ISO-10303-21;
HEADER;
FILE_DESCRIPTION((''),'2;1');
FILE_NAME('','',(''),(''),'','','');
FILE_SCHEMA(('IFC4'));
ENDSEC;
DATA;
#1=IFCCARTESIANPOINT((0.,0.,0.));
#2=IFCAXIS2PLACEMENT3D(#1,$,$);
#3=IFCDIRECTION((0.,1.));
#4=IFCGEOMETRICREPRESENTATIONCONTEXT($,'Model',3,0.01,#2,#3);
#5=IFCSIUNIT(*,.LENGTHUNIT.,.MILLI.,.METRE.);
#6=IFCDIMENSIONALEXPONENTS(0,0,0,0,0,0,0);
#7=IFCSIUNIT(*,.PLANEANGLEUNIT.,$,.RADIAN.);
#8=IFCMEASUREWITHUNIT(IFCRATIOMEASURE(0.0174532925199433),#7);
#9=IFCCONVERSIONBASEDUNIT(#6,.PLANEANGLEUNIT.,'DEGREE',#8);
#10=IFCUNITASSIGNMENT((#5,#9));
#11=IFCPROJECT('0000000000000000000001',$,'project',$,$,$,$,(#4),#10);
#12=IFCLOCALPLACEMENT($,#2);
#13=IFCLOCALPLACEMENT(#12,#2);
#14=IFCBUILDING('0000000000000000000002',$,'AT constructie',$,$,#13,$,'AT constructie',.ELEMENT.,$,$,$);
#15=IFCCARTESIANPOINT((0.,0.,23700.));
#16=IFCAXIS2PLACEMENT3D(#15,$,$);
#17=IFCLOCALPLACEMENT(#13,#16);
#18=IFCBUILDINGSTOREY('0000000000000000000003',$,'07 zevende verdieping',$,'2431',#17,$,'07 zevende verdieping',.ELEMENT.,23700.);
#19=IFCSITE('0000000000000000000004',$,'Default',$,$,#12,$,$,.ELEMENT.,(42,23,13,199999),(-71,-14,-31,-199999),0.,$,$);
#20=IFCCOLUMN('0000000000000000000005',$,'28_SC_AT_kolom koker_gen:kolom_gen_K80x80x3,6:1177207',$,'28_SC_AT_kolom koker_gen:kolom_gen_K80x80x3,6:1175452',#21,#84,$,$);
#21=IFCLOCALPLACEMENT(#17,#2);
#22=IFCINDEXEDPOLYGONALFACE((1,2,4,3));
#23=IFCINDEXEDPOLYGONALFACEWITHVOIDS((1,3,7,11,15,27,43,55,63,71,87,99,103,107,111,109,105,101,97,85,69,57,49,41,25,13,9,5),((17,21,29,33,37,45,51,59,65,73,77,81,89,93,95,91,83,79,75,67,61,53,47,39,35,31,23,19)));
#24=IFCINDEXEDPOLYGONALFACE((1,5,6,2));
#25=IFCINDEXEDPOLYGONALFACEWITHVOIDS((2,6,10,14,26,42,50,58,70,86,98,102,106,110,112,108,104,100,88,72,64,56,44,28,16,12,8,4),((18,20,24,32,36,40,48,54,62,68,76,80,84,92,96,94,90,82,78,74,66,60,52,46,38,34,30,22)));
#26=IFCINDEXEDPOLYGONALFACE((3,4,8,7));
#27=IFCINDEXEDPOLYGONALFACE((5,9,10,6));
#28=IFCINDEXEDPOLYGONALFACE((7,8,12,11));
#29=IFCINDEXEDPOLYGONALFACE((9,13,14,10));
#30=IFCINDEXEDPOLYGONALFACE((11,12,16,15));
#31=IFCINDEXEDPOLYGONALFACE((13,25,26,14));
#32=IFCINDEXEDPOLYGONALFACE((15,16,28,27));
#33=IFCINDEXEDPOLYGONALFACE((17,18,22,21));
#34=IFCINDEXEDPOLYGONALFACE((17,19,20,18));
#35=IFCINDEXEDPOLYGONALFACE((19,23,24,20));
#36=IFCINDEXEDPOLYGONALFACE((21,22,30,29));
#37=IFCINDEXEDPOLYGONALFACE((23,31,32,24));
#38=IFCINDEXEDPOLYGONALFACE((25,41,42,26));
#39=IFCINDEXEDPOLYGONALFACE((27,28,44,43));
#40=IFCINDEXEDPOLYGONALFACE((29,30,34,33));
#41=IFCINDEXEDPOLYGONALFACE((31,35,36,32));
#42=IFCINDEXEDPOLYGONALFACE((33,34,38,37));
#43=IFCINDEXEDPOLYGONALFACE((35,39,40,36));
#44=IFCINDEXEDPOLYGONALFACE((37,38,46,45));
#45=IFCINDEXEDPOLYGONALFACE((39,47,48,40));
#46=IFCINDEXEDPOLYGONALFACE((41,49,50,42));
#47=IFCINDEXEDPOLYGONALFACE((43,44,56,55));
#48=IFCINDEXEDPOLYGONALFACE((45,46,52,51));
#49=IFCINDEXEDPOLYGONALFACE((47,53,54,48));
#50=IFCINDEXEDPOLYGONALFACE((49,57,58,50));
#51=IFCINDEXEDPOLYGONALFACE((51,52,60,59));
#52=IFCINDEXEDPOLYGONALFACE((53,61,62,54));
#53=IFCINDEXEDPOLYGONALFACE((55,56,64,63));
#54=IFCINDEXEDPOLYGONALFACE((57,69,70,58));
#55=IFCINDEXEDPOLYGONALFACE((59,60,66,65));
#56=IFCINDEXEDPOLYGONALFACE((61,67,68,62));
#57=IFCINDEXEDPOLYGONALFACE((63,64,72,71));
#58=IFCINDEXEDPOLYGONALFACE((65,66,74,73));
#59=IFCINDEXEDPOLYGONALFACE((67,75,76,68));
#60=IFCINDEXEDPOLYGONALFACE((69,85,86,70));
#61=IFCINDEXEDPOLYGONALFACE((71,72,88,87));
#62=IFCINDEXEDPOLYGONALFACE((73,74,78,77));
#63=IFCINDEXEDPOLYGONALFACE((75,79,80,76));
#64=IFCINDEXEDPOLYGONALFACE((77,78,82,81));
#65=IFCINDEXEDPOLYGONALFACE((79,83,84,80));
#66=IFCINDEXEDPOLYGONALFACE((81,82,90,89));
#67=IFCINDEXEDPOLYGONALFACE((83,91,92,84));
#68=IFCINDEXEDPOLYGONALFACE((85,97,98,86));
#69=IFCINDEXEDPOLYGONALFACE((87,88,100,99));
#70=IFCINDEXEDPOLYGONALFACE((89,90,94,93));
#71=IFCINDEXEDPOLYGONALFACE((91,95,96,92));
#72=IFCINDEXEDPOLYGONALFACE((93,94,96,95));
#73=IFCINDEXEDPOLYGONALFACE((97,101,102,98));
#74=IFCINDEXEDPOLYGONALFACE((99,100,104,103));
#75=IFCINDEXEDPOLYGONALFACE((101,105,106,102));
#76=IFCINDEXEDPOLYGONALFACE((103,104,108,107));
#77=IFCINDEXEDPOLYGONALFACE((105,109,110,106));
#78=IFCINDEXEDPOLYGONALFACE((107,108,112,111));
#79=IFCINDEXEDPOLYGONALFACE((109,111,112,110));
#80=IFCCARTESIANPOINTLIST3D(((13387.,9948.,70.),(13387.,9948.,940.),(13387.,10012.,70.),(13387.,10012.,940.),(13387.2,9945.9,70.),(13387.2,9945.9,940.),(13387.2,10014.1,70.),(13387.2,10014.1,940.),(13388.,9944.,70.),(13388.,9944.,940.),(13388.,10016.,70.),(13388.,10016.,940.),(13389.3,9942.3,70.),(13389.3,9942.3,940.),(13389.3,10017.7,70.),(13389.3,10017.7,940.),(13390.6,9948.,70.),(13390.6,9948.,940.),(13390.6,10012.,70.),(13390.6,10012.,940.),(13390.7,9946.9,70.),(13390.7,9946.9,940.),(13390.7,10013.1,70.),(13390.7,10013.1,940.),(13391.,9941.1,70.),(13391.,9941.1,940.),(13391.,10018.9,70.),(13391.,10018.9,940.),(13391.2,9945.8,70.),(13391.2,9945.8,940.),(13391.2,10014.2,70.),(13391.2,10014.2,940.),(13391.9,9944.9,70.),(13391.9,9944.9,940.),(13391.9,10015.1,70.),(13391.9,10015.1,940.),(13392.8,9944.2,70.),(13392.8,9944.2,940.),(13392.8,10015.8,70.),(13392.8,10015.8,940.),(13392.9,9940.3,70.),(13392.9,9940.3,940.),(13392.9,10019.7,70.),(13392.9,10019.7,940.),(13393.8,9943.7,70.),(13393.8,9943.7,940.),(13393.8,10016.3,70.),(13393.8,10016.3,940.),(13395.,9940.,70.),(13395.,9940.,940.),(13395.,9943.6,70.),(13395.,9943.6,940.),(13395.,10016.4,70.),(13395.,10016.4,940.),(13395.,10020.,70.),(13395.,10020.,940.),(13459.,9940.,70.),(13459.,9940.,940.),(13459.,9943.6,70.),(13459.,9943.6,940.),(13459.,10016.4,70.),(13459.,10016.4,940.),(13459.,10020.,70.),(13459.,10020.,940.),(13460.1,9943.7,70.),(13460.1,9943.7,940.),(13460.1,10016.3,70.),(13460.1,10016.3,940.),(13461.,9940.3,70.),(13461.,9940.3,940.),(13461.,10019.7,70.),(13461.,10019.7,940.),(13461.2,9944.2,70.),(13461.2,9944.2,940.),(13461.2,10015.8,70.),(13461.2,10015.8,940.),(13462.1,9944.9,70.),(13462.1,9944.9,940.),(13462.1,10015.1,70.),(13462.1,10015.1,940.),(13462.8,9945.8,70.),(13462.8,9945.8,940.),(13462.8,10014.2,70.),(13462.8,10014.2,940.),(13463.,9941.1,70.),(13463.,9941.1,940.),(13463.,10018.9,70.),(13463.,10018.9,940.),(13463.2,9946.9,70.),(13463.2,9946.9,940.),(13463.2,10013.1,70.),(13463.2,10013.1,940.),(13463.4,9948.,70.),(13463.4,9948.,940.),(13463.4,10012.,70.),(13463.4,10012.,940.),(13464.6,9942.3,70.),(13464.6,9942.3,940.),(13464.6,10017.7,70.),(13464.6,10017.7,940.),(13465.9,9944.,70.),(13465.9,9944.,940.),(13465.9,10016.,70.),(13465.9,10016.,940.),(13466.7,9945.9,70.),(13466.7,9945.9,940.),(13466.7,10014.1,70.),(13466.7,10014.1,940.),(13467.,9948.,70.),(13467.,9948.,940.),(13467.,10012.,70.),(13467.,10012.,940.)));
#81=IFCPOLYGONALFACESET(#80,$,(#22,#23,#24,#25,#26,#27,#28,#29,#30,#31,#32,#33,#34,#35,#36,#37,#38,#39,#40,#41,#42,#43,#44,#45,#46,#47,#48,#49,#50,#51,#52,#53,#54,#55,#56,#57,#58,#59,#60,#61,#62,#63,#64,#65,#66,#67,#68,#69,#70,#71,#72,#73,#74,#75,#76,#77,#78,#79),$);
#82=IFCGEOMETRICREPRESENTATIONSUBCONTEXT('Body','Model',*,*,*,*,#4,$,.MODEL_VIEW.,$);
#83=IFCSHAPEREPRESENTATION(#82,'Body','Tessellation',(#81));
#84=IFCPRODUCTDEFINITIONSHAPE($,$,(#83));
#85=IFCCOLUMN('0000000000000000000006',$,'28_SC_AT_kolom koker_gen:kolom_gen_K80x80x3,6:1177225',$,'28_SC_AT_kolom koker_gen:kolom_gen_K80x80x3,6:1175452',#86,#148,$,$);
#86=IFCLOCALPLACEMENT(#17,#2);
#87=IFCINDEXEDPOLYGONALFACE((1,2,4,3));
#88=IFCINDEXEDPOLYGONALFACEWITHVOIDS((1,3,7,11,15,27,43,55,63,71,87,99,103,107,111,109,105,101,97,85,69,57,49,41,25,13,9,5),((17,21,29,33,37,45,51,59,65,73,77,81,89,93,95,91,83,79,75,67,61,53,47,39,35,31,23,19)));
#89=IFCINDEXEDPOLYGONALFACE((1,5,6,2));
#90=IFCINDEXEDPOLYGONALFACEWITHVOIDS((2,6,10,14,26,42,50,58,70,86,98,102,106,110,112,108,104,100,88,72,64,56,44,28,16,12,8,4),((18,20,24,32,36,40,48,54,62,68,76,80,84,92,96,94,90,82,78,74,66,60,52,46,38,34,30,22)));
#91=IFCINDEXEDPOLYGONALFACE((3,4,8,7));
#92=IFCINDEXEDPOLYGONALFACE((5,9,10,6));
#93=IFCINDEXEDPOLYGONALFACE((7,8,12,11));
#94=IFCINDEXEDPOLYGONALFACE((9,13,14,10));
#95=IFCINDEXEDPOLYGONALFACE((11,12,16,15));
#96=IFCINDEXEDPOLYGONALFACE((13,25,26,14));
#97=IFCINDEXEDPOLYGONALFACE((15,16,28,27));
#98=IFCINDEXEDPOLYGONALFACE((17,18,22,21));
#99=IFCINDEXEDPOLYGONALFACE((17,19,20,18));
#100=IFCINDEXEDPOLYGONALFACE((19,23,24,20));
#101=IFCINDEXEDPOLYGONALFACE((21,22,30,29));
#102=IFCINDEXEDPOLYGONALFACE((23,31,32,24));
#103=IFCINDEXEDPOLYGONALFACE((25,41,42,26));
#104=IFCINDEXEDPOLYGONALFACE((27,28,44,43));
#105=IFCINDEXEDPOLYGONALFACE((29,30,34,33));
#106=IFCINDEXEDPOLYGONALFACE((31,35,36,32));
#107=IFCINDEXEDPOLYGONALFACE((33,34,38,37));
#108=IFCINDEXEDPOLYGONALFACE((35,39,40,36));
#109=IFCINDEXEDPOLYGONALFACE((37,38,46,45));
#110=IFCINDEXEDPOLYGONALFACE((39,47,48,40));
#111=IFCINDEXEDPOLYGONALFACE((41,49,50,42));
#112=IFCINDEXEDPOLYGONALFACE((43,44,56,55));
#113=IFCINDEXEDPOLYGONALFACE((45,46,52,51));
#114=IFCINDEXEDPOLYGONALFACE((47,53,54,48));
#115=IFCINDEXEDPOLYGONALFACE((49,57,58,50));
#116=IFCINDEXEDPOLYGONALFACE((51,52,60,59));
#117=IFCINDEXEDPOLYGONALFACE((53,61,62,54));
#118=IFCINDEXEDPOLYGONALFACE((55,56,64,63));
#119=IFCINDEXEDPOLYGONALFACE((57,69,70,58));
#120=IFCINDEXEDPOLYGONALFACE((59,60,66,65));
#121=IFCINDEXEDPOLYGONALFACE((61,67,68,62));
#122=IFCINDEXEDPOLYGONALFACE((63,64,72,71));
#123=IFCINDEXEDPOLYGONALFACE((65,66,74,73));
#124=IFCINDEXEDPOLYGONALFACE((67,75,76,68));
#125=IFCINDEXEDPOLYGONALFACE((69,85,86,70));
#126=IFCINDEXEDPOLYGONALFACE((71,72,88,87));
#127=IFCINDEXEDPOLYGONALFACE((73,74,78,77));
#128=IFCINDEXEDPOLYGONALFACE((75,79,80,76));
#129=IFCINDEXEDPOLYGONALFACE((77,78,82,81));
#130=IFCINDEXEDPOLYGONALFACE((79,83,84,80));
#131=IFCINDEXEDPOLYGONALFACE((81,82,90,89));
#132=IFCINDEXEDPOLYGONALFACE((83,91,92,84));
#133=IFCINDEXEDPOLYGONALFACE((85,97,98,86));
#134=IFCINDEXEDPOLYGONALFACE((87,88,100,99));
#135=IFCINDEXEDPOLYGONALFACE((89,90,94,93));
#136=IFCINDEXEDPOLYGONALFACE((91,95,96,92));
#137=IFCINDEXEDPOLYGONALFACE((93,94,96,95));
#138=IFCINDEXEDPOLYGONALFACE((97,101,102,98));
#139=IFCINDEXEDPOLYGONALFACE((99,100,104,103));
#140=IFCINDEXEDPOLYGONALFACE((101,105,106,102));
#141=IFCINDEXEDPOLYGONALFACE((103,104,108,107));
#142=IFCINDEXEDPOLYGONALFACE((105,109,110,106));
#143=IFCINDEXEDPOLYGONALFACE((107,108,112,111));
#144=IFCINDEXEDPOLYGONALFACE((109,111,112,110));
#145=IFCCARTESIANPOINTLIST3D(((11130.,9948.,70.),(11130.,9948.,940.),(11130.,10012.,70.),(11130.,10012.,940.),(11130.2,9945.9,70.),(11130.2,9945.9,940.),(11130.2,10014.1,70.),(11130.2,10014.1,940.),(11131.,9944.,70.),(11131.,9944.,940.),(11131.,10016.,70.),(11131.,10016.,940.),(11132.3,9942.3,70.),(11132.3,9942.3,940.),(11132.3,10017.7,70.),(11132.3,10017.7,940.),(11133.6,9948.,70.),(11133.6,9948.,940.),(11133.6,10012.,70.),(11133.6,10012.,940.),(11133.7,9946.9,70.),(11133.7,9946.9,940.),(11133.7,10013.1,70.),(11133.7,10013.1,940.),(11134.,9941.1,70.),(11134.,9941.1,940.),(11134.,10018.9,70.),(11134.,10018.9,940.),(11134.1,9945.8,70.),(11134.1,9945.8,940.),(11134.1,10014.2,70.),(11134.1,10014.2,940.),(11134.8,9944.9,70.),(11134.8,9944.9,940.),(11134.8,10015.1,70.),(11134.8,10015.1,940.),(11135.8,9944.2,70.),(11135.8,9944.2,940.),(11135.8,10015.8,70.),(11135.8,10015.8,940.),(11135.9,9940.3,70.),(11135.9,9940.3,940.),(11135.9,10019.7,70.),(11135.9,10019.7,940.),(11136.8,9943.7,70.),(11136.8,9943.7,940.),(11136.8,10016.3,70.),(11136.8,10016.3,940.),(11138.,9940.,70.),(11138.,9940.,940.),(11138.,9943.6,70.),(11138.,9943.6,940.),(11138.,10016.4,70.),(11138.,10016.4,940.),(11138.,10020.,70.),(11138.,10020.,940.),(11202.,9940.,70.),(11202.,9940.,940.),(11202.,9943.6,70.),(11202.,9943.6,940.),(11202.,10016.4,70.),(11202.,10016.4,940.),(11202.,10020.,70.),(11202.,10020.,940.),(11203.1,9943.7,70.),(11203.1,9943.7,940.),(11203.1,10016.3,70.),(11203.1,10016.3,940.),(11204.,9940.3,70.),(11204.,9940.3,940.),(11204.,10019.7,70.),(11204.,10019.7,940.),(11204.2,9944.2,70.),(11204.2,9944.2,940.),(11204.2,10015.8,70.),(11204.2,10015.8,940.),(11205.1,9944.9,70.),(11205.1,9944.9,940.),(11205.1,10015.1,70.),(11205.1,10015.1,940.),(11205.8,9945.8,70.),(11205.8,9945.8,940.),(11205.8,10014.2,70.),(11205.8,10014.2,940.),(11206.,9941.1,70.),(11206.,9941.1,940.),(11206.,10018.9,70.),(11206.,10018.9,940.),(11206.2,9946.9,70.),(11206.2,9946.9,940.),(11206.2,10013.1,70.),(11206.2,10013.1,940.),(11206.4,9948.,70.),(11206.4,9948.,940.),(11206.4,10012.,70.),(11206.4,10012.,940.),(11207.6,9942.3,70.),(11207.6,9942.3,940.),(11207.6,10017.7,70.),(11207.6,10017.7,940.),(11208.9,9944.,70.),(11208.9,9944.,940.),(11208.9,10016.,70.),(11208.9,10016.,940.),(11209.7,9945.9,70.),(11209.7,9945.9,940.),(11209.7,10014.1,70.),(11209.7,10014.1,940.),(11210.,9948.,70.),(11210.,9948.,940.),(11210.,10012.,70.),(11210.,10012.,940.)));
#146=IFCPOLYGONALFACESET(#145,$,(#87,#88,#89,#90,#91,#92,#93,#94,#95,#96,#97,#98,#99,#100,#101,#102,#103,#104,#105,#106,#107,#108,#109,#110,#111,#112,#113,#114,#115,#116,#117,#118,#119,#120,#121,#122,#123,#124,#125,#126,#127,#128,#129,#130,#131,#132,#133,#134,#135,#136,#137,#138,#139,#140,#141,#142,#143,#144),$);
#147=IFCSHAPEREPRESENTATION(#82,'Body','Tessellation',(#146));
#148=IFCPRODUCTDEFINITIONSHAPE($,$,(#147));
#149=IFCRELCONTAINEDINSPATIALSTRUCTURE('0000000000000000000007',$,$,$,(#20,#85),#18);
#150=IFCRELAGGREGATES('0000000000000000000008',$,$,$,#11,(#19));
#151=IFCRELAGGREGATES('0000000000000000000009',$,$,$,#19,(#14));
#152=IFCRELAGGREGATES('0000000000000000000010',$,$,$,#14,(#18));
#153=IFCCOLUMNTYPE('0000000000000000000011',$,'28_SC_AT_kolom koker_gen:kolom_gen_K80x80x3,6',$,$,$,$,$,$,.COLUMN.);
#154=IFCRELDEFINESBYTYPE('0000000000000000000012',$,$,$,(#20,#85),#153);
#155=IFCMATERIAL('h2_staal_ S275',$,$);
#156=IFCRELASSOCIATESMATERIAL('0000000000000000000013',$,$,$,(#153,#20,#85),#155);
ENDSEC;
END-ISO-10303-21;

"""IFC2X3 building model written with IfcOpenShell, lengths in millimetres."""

from ifc_helpers import new_model, entity, si_unit, converted_unit, direction, frame, frame_2d, origin, place, context, subcontext, project, spatial, polyline, circle_curve, parameter, trimmed, segment, composite_curve, outline, extrude, source, transform, mapped, material, type_object, type_shapes, element, save


model = new_model("IFC2X3")

# Units and contexts
model_context = context("Model", 3, precision=0.01, world=origin(), true_north=direction((0.0, 1.0)))
body_context = subcontext(model_context, "Body", "Model", "MODEL_VIEW")
ifc_project = project(units=[si_unit("LENGTHUNIT", "METRE", prefix="MILLI"), converted_unit("PLANEANGLEUNIT", "DEGREE", entity("IfcRatioMeasure", 0.0174532925199433), si_unit("PLANEANGLEUNIT", "RADIAN"), dimensions=[0, 0, 0, 0, 0, 0, 0])], contexts=[model_context])

# Site, building, storey
site_placement = place(None, origin())
site = spatial("IfcSite", under=ifc_project, at=site_placement, Name="Default", CompositionType="ELEMENT", RefLatitude=(42, 23, 13, 199999), RefLongitude=(-71, -14, -31, -199999), RefElevation=0.0)
building_placement = place(site_placement, origin())
building = spatial("IfcBuilding", under=site, at=building_placement, Name="AT constructie", LongName="AT constructie", CompositionType="ELEMENT")
storey_placement = place(building_placement, frame((0.0, 0.0, 23700.0)))
storey = spatial("IfcBuildingStorey", under=building, at=storey_placement, Name="07 zevende verdieping", ObjectType="2431", LongName="07 zevende verdieping", CompositionType="ELEMENT", Elevation=23700.0)

# Columns
ifc_material = material(Name="h2_staal_ S275")
column_type_1 = type_object("IfcColumnType", Name="28_SC_AT_kolom koker_gen:kolom_gen_K80x80x3,6", PredefinedType="COLUMN", material=ifc_material)
shared_shape_1 = source(origin(), body_context, "Body", "SweptSolid", [
    extrude(outline(composite_curve([segment(trimmed(circle_curve(frame_2d((32.0, 32.0), x_axis=(1.0, 0.0)), 8.0), [parameter(360.0)], [parameter(90.0)], True, "PARAMETER"), True, "CONTINUOUS"), segment(polyline([(32.0, 40.0), (-32.0, 40.0)]), True, "CONTINUOUS"), segment(trimmed(circle_curve(frame_2d((-32.0, 32.0), x_axis=(1.0, 0.0)), 8.0), [parameter(90.0)], [parameter(180.0)], True, "PARAMETER"), True, "CONTINUOUS"), segment(polyline([(-40.0, 32.0), (-40.0, -32.0)]), True, "CONTINUOUS"), segment(trimmed(circle_curve(frame_2d((-32.0, -32.0), x_axis=(1.0, 0.0)), 8.0), [parameter(180.0)], [parameter(270.0)], True, "PARAMETER"), True, "CONTINUOUS"), segment(polyline([(-32.0, -40.0), (32.0, -40.0)]), True, "CONTINUOUS"), segment(trimmed(circle_curve(frame_2d((32.0, -32.0), x_axis=(1.0, 0.0)), 8.0), [parameter(270.0)], [parameter(0.0)], True, "PARAMETER"), True, "CONTINUOUS"), segment(polyline([(40.0, -32.0), (40.0, 32.0)]), True, "CONTINUOUS")], self_intersect=False), holes=[composite_curve([segment(polyline([(-32.0, 36.4), (32.0, 36.4)]), True, "CONTINUOUS"), segment(trimmed(circle_curve(frame_2d((32.0, 32.0), x_axis=(1.0, 0.0)), 4.4), [parameter(360.0)], [parameter(90.0)], True, "PARAMETER"), False, "CONTINUOUS"), segment(polyline([(36.4, 32.0), (36.4, -32.0)]), True, "CONTINUOUS"), segment(trimmed(circle_curve(frame_2d((32.0, -32.0), x_axis=(1.0, 0.0)), 4.4), [parameter(270.0)], [parameter(360.0)], True, "PARAMETER"), False, "CONTINUOUS"), segment(polyline([(32.0, -36.4), (-32.0, -36.4)]), True, "CONTINUOUS"), segment(trimmed(circle_curve(frame_2d((-32.0, -32.0), x_axis=(1.0, 0.0)), 4.4), [parameter(180.0)], [parameter(270.0)], True, "PARAMETER"), False, "CONTINUOUS"), segment(polyline([(-36.4, -32.0), (-36.4, 32.0)]), True, "CONTINUOUS"), segment(trimmed(circle_curve(frame_2d((-32.0, 32.0), x_axis=(1.0, 0.0)), 4.4), [parameter(90.0)], [parameter(180.0)], True, "PARAMETER"), False, "CONTINUOUS")], self_intersect=False)]), frame((0.0, 0.0, 23770.0), z_axis=(0.0, 0.0, 1.0), x_axis=(-1.0, 0.0, 0.0)), (0.0, 0.0, 1.0), 870.0),
])
type_shapes(column_type_1, [shared_shape_1])
for number, where, name in (
    (1, (13427.0, 9980.0, -23700.0), "28_SC_AT_kolom koker_gen:kolom_gen_K80x80x3,6:1177207"),
    (2, (11170.0, 9980.0, -23700.0), "28_SC_AT_kolom koker_gen:kolom_gen_K80x80x3,6:1177225"),
):
    element("IfcColumn", number, at=place(storey_placement, frame(where)), inside=storey, type_object=column_type_1, material=ifc_material, Name=name, ObjectType="28_SC_AT_kolom koker_gen:kolom_gen_K80x80x3,6:1175452", context=body_context, shape_type="MappedRepresentation", body=[
        mapped(shared_shape_1, transform((0.0, 0.0, 0.0), scale=1.0)),
    ])

save(model, "model.ifc")
